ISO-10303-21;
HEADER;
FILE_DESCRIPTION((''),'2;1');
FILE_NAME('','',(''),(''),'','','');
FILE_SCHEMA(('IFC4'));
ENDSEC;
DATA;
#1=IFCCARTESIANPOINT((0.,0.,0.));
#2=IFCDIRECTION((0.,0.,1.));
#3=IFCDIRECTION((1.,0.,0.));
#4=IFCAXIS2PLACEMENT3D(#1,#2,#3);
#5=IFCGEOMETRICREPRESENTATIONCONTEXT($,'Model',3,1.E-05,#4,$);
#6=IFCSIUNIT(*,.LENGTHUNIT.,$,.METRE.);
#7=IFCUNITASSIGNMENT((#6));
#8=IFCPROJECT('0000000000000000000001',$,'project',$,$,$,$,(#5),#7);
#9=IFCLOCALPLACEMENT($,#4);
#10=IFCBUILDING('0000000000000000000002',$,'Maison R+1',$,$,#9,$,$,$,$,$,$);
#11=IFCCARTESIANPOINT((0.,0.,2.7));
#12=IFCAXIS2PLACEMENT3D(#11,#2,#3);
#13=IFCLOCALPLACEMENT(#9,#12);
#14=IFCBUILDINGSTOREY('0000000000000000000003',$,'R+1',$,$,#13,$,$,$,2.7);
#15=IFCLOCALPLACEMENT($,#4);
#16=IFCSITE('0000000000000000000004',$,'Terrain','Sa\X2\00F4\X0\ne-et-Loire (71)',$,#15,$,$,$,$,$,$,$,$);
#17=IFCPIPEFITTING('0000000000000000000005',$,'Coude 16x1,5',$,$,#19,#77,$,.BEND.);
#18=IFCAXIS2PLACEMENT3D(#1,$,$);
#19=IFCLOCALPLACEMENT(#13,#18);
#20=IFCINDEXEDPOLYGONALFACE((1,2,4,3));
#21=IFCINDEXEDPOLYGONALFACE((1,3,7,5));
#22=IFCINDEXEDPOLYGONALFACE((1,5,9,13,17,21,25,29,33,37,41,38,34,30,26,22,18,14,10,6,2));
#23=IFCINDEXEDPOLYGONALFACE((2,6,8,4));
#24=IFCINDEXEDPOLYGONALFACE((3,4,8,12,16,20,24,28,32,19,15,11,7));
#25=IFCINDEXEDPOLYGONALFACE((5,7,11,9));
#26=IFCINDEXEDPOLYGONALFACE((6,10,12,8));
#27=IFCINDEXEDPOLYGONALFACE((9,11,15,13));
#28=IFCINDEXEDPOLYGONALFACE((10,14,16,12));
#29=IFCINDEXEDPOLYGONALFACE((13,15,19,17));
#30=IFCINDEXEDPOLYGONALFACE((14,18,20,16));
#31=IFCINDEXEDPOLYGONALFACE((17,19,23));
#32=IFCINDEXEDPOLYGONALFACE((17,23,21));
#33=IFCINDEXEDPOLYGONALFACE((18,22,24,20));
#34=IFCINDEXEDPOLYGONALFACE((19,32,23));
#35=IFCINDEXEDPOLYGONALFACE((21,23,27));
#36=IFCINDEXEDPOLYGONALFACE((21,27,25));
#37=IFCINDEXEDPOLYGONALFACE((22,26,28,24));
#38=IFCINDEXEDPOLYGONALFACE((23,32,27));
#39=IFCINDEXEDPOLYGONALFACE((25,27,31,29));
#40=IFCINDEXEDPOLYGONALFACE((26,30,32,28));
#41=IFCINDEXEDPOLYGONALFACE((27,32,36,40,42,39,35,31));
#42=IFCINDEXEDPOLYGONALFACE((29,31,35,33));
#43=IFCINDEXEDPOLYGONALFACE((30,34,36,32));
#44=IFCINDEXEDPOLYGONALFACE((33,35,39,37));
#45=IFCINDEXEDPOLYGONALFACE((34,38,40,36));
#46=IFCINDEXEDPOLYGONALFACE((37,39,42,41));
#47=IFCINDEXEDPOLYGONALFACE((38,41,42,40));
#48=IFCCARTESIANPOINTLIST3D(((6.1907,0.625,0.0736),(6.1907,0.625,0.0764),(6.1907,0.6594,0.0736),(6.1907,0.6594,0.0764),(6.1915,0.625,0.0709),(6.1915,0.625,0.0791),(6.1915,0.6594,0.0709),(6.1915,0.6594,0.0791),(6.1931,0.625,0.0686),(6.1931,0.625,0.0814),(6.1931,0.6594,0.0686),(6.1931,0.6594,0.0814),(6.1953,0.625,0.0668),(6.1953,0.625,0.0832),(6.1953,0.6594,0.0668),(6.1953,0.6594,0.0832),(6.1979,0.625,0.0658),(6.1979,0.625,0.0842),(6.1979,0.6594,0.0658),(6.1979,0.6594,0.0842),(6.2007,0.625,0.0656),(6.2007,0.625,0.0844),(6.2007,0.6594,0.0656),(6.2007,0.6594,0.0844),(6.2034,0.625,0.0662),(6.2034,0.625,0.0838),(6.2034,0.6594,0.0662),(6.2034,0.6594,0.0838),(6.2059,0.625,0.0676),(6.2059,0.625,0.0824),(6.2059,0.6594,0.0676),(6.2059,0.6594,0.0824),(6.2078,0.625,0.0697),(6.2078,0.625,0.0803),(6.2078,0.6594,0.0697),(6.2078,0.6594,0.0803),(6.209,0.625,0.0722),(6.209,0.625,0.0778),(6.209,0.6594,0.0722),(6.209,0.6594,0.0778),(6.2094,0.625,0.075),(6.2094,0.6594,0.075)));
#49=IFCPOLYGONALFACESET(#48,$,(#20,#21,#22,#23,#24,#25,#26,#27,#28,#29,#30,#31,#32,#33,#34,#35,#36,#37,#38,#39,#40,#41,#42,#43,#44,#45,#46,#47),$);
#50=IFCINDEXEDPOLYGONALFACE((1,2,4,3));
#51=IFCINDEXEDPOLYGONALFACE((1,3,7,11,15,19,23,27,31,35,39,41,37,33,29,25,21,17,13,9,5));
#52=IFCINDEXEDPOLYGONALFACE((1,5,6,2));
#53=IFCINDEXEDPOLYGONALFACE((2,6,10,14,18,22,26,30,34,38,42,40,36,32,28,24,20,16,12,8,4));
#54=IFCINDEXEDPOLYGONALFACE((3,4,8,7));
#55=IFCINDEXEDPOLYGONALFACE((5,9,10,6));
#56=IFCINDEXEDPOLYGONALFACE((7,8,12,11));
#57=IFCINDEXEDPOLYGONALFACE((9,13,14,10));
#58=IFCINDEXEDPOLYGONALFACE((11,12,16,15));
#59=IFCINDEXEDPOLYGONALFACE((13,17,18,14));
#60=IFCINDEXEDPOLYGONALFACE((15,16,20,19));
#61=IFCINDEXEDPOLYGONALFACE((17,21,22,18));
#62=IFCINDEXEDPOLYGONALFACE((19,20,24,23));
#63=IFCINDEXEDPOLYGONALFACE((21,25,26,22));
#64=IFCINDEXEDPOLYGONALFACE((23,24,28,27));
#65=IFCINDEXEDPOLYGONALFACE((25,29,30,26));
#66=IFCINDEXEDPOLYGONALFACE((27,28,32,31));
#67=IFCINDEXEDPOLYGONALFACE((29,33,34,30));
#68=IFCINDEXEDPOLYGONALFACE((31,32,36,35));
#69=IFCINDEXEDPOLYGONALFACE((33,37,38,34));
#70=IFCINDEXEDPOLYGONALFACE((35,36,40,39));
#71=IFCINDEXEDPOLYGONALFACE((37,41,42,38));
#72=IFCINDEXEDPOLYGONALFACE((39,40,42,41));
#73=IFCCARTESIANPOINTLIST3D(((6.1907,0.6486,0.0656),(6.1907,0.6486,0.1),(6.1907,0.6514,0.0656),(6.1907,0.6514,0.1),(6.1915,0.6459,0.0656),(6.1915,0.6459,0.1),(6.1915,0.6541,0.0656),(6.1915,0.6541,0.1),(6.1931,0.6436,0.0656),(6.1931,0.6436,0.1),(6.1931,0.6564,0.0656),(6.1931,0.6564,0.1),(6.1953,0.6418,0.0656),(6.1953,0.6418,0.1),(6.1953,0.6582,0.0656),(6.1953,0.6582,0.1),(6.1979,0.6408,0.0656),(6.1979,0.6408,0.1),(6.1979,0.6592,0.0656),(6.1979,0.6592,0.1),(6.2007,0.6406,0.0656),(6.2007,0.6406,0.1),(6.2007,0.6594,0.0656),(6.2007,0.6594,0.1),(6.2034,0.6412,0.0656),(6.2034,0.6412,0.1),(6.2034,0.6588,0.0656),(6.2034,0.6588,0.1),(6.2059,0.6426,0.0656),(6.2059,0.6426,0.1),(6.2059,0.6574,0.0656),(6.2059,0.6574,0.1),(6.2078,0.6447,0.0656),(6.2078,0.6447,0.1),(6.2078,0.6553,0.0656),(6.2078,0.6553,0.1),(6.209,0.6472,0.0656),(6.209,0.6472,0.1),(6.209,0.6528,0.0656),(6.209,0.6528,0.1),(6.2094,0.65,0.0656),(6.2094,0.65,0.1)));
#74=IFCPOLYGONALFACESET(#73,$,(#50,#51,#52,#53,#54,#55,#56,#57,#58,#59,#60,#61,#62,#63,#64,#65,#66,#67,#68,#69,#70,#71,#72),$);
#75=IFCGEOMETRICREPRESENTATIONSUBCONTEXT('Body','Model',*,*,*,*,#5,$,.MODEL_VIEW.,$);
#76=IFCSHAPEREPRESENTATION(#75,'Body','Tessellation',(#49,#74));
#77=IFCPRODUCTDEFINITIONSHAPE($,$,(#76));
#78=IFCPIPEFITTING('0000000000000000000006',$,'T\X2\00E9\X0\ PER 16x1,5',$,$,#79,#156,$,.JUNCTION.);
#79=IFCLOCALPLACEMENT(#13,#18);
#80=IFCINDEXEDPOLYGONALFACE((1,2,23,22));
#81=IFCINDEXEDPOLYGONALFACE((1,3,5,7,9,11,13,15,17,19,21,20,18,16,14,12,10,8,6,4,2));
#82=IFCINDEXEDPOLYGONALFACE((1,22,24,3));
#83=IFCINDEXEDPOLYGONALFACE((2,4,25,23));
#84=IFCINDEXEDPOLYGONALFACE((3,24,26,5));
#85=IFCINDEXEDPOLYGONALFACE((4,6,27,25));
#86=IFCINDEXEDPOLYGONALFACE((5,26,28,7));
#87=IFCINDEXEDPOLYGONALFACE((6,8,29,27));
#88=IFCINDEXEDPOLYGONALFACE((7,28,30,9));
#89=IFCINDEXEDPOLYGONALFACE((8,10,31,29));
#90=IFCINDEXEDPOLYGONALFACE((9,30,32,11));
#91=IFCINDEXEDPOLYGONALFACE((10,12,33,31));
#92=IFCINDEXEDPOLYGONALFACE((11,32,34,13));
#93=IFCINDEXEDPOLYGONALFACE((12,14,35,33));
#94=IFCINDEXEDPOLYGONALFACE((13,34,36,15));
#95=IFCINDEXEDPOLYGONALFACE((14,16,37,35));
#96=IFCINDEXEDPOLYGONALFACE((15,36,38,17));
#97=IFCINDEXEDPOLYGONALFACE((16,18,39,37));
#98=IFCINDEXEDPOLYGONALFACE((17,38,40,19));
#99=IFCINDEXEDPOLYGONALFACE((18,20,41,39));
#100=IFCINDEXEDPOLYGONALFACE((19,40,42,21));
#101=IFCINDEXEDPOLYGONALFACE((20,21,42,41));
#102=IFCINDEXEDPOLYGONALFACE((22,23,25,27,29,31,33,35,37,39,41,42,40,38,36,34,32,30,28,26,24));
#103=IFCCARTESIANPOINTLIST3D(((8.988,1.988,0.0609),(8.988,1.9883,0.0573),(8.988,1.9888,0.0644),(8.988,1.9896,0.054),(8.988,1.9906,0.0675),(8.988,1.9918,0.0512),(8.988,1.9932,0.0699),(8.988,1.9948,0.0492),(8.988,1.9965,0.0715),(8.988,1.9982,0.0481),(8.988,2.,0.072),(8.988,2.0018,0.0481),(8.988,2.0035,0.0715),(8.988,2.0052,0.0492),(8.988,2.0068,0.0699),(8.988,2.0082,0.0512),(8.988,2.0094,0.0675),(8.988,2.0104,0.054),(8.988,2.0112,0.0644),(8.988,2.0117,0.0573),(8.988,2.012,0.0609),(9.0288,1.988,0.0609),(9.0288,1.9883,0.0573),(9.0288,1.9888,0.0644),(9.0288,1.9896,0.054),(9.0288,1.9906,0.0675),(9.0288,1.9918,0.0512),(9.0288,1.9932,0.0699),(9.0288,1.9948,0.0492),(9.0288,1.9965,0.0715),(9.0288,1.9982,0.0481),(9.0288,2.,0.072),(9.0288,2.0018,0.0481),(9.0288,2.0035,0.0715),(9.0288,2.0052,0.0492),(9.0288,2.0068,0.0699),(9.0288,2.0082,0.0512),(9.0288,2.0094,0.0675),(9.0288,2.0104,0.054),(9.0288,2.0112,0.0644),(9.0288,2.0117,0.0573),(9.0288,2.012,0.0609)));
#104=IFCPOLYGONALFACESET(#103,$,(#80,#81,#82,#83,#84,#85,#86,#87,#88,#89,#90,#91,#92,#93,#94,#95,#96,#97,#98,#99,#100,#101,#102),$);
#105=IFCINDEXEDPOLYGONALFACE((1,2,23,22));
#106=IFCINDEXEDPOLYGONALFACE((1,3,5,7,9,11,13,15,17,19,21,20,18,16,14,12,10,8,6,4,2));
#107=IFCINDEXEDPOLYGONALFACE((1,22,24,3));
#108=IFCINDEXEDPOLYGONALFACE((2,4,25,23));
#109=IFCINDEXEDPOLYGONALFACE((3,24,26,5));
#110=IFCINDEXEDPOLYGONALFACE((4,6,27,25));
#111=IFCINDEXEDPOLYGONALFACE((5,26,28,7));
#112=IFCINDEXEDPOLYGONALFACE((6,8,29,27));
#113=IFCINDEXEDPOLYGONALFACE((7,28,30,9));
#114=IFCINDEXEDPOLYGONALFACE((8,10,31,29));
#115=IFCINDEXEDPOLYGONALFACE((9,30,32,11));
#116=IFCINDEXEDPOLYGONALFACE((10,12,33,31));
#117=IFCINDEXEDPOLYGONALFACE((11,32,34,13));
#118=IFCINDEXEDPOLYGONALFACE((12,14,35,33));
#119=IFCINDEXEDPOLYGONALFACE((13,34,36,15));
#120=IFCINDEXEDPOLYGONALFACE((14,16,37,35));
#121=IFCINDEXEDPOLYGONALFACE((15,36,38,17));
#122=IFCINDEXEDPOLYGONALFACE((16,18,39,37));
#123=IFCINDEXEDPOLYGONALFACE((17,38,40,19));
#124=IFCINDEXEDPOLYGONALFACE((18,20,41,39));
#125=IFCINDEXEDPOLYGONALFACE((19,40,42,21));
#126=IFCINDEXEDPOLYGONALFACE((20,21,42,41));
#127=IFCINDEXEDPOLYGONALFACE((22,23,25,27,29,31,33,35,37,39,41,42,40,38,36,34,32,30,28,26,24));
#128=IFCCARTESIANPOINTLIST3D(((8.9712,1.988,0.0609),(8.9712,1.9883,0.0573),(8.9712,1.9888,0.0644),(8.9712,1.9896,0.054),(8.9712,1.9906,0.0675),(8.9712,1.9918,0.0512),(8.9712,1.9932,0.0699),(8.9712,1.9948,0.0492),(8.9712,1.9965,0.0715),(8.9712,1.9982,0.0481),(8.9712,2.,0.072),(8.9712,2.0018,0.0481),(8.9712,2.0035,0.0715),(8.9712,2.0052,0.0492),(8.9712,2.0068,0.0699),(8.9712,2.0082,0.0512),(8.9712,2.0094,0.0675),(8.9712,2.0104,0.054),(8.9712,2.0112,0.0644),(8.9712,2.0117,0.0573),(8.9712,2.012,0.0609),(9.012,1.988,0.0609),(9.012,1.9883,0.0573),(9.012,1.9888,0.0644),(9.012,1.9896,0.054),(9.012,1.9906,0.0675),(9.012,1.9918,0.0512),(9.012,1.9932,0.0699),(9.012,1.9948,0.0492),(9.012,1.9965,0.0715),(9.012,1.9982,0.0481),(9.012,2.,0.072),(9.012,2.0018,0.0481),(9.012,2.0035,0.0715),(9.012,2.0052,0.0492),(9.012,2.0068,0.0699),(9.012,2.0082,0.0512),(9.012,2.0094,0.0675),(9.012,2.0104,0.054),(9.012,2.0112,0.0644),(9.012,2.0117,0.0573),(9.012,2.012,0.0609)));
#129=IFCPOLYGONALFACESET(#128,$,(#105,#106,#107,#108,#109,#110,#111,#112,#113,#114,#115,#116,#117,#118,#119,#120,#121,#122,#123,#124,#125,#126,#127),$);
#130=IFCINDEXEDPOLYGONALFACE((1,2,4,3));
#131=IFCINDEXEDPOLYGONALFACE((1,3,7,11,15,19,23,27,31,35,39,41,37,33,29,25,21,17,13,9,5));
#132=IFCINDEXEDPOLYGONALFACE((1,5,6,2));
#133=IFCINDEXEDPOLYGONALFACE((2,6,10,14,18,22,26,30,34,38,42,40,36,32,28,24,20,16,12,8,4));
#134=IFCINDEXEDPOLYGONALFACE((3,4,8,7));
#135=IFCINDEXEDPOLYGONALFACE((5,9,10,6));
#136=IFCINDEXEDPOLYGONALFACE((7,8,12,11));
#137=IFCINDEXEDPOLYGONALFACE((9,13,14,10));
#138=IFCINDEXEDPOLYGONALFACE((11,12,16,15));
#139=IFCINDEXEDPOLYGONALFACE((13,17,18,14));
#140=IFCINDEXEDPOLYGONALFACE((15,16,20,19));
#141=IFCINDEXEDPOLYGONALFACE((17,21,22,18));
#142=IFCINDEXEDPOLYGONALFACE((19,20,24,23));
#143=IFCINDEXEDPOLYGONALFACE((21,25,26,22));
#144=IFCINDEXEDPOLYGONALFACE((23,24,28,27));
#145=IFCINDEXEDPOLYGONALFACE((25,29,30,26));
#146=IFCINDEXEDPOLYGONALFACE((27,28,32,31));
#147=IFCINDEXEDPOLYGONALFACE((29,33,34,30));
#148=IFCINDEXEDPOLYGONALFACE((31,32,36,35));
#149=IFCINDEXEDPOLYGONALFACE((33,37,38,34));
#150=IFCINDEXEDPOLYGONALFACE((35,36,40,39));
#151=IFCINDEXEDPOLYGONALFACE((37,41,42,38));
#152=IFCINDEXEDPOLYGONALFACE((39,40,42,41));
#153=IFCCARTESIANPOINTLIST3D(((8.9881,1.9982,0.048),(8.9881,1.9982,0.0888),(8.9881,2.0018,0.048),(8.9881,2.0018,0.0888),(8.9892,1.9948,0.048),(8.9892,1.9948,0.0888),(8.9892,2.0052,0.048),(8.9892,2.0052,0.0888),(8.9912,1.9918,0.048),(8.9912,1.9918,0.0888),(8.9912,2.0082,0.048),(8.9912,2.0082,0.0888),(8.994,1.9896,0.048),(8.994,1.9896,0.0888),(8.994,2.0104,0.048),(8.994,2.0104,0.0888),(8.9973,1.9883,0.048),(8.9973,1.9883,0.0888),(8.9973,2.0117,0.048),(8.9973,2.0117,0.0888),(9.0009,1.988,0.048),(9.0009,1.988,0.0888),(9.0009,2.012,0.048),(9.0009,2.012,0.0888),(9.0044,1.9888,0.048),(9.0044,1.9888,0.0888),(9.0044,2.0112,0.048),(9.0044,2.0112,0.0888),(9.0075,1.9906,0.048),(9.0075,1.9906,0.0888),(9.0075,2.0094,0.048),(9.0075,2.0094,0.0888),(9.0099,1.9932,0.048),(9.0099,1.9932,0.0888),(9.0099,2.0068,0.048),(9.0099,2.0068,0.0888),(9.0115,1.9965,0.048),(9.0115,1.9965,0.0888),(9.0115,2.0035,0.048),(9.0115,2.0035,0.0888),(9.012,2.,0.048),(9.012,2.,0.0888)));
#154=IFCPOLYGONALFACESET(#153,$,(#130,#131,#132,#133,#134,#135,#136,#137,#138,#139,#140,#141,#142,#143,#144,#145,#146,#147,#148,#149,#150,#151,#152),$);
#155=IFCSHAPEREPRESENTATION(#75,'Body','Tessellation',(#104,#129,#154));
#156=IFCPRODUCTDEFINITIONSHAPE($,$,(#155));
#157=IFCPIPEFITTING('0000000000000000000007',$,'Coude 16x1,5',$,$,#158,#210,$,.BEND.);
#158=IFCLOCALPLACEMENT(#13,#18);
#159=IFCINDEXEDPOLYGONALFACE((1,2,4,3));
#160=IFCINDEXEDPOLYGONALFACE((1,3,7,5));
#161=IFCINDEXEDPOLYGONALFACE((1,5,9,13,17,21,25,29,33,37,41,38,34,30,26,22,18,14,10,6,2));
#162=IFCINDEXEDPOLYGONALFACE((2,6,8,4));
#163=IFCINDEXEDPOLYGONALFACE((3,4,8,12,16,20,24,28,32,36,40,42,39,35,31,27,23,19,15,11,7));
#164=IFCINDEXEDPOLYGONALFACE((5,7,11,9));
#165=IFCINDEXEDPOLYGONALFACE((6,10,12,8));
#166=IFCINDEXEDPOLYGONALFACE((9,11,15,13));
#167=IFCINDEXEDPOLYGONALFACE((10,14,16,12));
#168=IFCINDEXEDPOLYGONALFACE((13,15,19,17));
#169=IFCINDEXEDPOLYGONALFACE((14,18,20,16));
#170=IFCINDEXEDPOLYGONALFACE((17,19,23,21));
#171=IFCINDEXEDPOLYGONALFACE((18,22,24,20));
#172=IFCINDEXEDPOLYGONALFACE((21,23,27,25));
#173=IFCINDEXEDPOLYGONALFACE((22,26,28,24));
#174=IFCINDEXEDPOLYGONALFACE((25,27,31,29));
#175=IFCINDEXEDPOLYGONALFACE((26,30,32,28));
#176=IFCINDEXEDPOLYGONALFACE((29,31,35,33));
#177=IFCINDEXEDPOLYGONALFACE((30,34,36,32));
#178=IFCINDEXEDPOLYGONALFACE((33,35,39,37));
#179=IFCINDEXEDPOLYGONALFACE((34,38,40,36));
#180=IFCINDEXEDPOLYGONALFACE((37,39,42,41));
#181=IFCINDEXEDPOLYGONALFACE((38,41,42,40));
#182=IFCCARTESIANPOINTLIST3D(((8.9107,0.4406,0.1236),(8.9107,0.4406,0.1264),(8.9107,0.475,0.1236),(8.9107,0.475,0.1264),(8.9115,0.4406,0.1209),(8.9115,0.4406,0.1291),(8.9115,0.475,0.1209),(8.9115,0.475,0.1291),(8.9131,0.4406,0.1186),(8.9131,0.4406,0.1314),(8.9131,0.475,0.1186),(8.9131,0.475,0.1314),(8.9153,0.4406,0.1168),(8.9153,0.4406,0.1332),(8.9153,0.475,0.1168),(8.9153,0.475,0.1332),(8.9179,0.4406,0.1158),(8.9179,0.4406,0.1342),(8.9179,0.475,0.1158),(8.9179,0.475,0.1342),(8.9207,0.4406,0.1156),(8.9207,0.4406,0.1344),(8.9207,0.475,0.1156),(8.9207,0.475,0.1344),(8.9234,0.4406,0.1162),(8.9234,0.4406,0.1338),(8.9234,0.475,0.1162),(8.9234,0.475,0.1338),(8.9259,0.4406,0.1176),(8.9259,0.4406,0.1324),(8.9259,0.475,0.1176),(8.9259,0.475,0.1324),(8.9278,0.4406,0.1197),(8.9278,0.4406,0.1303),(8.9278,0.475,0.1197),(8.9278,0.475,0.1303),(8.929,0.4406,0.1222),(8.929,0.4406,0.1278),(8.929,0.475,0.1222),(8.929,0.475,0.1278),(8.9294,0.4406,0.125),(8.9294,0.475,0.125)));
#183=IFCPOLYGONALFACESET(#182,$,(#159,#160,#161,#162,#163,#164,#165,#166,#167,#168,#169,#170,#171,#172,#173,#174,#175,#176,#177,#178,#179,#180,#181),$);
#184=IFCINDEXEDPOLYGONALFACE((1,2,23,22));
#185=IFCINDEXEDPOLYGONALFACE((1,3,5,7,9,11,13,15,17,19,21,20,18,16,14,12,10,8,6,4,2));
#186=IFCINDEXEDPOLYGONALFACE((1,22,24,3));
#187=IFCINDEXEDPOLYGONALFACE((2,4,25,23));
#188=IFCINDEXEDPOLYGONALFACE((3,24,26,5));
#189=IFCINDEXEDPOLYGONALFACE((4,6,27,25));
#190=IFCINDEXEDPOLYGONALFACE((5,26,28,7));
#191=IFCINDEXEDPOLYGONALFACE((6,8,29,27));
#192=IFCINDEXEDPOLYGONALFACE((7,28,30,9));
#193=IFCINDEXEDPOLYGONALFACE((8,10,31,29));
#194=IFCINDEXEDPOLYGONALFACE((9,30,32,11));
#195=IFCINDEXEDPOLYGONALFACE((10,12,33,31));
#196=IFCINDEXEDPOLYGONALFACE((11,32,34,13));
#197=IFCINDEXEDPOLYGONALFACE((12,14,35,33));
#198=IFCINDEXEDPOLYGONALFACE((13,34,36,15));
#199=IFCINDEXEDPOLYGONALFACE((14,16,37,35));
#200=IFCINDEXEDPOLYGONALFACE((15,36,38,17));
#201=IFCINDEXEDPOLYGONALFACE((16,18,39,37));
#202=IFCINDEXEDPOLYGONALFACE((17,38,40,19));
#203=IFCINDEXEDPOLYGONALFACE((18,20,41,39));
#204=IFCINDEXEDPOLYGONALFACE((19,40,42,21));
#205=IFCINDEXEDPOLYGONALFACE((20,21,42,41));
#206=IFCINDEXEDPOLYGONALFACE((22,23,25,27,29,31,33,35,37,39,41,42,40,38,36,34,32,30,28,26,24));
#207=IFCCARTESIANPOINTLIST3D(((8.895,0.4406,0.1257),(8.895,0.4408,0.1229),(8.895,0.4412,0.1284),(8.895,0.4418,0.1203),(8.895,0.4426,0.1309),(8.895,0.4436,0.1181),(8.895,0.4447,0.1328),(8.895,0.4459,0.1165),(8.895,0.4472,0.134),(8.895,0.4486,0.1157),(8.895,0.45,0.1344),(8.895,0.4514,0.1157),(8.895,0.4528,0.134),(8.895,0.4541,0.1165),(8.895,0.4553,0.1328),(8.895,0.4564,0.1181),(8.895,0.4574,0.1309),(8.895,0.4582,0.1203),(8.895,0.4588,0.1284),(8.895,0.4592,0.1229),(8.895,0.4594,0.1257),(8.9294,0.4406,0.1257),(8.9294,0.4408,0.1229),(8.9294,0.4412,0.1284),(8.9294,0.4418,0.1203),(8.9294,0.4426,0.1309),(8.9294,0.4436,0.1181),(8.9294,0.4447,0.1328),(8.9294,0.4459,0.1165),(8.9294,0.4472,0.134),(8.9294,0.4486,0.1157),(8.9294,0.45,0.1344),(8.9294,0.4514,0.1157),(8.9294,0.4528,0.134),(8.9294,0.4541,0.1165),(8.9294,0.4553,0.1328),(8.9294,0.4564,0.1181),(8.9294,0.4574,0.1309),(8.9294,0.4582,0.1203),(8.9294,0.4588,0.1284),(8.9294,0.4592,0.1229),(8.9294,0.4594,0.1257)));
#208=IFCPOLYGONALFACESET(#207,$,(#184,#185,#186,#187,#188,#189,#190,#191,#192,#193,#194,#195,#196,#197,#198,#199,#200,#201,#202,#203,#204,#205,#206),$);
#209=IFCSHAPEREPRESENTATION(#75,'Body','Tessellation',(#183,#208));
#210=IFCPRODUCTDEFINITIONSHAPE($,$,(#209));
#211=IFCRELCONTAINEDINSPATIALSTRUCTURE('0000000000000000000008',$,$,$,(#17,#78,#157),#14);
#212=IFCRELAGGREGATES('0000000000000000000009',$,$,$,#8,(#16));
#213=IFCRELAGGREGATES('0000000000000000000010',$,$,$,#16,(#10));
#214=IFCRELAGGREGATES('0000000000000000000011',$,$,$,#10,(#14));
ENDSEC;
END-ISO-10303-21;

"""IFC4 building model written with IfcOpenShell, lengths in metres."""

from ifc_helpers import new_model, si_unit, frame, origin_with_axes, place, context, subcontext, project, spatial, circle, extrude, element, save


model = new_model("IFC4")

# Units and contexts
model_context = context("Model", 3, precision=1e-05, world=origin_with_axes())
body_context = subcontext(model_context, "Body", "Model", "MODEL_VIEW")
ifc_project = project(units=[si_unit("LENGTHUNIT", "METRE")], contexts=[model_context])

# Site, building, storey
site_placement = place(None, origin_with_axes())
site = spatial("IfcSite", under=ifc_project, at=site_placement, Name="Terrain", Description="Saône-et-Loire (71)")
building_placement = place(None, origin_with_axes())
building = spatial("IfcBuilding", under=site, at=building_placement, Name="Maison R+1")
storey_placement = place(building_placement, frame((0.0, 0.0, 2.7), z_axis=(0.0, 0.0, 1.0), x_axis=(1.0, 0.0, 0.0)))
storey = spatial("IfcBuildingStorey", under=building, at=storey_placement, Name="R+1", Elevation=2.7)

# Pipe fittings
pipe_fitting_1_placement = place(storey_placement, frame((6.2, 0.65, 0.075), z_axis=(0.0, 0.0, 1.0), x_axis=(1.0, 0.0, 0.0)))
element("IfcPipeFitting", 1, at=pipe_fitting_1_placement, inside=storey, Name="Coude 16x1,5", PredefinedType="BEND", context=body_context, shape_type="SweptSolid", body=[
    extrude(circle(Radius=0.0094), frame((0.0, 0.0094, 0.0), z_axis=(0.0, -1.0, 0.0), x_axis=(1.0, 0.0, 0.0)), (0.0, 0.0, 1.0), 0.0344),
    extrude(circle(Radius=0.0094), frame((0.0, 0.0, -0.0094), z_axis=(0.0, 0.0, 1.0), x_axis=(1.0, 0.0, 0.0)), (0.0, 0.0, 1.0), 0.0344),
])
pipe_fitting_2_placement = place(storey_placement, frame((9.0, 2.0, 0.06), z_axis=(0.0, 0.0, 1.0), x_axis=(1.0, 0.0, 0.0)))
element("IfcPipeFitting", 2, at=pipe_fitting_2_placement, inside=storey, Name="Té PER 16x1,5", PredefinedType="JUNCTION", context=body_context, shape_type="SweptSolid", body=[
    extrude(circle(Radius=0.012), frame((-0.012, 0.0, 0.0), z_axis=(1.0, 0.0, 0.0), x_axis=(0.0, 0.0, 1.0)), (0.0, 0.0, 1.0), 0.0408),
    extrude(circle(Radius=0.012), frame((0.012, 0.0, 0.0), z_axis=(-1.0, 0.0, 0.0), x_axis=(0.0, 0.0, 1.0)), (0.0, 0.0, 1.0), 0.0408),
    extrude(circle(Radius=0.012), frame((0.0, 0.0, -0.012), z_axis=(0.0, 0.0, 1.0), x_axis=(1.0, 0.0, 0.0)), (0.0, 0.0, 1.0), 0.0408),
])
pipe_fitting_3_placement = place(storey_placement, frame((8.92, 0.45, 0.125), z_axis=(0.0, 0.0, 1.0), x_axis=(1.0, 0.0, 0.0)))
element("IfcPipeFitting", 3, at=pipe_fitting_3_placement, inside=storey, Name="Coude 16x1,5", PredefinedType="BEND", context=body_context, shape_type="SweptSolid", body=[
    extrude(circle(Radius=0.0094), frame((0.0, -0.0094, 0.0), z_axis=(0.0, 1.0, 0.0), x_axis=(1.0, 0.0, 0.0)), (0.0, 0.0, 1.0), 0.0344),
    extrude(circle(Radius=0.0094), frame((0.0094, 0.0, 0.0), z_axis=(-1.0, 0.0, 0.0), x_axis=(0.0, 0.0, 1.0)), (0.0, 0.0, 1.0), 0.0344),
])

save(model, "model.ifc")
